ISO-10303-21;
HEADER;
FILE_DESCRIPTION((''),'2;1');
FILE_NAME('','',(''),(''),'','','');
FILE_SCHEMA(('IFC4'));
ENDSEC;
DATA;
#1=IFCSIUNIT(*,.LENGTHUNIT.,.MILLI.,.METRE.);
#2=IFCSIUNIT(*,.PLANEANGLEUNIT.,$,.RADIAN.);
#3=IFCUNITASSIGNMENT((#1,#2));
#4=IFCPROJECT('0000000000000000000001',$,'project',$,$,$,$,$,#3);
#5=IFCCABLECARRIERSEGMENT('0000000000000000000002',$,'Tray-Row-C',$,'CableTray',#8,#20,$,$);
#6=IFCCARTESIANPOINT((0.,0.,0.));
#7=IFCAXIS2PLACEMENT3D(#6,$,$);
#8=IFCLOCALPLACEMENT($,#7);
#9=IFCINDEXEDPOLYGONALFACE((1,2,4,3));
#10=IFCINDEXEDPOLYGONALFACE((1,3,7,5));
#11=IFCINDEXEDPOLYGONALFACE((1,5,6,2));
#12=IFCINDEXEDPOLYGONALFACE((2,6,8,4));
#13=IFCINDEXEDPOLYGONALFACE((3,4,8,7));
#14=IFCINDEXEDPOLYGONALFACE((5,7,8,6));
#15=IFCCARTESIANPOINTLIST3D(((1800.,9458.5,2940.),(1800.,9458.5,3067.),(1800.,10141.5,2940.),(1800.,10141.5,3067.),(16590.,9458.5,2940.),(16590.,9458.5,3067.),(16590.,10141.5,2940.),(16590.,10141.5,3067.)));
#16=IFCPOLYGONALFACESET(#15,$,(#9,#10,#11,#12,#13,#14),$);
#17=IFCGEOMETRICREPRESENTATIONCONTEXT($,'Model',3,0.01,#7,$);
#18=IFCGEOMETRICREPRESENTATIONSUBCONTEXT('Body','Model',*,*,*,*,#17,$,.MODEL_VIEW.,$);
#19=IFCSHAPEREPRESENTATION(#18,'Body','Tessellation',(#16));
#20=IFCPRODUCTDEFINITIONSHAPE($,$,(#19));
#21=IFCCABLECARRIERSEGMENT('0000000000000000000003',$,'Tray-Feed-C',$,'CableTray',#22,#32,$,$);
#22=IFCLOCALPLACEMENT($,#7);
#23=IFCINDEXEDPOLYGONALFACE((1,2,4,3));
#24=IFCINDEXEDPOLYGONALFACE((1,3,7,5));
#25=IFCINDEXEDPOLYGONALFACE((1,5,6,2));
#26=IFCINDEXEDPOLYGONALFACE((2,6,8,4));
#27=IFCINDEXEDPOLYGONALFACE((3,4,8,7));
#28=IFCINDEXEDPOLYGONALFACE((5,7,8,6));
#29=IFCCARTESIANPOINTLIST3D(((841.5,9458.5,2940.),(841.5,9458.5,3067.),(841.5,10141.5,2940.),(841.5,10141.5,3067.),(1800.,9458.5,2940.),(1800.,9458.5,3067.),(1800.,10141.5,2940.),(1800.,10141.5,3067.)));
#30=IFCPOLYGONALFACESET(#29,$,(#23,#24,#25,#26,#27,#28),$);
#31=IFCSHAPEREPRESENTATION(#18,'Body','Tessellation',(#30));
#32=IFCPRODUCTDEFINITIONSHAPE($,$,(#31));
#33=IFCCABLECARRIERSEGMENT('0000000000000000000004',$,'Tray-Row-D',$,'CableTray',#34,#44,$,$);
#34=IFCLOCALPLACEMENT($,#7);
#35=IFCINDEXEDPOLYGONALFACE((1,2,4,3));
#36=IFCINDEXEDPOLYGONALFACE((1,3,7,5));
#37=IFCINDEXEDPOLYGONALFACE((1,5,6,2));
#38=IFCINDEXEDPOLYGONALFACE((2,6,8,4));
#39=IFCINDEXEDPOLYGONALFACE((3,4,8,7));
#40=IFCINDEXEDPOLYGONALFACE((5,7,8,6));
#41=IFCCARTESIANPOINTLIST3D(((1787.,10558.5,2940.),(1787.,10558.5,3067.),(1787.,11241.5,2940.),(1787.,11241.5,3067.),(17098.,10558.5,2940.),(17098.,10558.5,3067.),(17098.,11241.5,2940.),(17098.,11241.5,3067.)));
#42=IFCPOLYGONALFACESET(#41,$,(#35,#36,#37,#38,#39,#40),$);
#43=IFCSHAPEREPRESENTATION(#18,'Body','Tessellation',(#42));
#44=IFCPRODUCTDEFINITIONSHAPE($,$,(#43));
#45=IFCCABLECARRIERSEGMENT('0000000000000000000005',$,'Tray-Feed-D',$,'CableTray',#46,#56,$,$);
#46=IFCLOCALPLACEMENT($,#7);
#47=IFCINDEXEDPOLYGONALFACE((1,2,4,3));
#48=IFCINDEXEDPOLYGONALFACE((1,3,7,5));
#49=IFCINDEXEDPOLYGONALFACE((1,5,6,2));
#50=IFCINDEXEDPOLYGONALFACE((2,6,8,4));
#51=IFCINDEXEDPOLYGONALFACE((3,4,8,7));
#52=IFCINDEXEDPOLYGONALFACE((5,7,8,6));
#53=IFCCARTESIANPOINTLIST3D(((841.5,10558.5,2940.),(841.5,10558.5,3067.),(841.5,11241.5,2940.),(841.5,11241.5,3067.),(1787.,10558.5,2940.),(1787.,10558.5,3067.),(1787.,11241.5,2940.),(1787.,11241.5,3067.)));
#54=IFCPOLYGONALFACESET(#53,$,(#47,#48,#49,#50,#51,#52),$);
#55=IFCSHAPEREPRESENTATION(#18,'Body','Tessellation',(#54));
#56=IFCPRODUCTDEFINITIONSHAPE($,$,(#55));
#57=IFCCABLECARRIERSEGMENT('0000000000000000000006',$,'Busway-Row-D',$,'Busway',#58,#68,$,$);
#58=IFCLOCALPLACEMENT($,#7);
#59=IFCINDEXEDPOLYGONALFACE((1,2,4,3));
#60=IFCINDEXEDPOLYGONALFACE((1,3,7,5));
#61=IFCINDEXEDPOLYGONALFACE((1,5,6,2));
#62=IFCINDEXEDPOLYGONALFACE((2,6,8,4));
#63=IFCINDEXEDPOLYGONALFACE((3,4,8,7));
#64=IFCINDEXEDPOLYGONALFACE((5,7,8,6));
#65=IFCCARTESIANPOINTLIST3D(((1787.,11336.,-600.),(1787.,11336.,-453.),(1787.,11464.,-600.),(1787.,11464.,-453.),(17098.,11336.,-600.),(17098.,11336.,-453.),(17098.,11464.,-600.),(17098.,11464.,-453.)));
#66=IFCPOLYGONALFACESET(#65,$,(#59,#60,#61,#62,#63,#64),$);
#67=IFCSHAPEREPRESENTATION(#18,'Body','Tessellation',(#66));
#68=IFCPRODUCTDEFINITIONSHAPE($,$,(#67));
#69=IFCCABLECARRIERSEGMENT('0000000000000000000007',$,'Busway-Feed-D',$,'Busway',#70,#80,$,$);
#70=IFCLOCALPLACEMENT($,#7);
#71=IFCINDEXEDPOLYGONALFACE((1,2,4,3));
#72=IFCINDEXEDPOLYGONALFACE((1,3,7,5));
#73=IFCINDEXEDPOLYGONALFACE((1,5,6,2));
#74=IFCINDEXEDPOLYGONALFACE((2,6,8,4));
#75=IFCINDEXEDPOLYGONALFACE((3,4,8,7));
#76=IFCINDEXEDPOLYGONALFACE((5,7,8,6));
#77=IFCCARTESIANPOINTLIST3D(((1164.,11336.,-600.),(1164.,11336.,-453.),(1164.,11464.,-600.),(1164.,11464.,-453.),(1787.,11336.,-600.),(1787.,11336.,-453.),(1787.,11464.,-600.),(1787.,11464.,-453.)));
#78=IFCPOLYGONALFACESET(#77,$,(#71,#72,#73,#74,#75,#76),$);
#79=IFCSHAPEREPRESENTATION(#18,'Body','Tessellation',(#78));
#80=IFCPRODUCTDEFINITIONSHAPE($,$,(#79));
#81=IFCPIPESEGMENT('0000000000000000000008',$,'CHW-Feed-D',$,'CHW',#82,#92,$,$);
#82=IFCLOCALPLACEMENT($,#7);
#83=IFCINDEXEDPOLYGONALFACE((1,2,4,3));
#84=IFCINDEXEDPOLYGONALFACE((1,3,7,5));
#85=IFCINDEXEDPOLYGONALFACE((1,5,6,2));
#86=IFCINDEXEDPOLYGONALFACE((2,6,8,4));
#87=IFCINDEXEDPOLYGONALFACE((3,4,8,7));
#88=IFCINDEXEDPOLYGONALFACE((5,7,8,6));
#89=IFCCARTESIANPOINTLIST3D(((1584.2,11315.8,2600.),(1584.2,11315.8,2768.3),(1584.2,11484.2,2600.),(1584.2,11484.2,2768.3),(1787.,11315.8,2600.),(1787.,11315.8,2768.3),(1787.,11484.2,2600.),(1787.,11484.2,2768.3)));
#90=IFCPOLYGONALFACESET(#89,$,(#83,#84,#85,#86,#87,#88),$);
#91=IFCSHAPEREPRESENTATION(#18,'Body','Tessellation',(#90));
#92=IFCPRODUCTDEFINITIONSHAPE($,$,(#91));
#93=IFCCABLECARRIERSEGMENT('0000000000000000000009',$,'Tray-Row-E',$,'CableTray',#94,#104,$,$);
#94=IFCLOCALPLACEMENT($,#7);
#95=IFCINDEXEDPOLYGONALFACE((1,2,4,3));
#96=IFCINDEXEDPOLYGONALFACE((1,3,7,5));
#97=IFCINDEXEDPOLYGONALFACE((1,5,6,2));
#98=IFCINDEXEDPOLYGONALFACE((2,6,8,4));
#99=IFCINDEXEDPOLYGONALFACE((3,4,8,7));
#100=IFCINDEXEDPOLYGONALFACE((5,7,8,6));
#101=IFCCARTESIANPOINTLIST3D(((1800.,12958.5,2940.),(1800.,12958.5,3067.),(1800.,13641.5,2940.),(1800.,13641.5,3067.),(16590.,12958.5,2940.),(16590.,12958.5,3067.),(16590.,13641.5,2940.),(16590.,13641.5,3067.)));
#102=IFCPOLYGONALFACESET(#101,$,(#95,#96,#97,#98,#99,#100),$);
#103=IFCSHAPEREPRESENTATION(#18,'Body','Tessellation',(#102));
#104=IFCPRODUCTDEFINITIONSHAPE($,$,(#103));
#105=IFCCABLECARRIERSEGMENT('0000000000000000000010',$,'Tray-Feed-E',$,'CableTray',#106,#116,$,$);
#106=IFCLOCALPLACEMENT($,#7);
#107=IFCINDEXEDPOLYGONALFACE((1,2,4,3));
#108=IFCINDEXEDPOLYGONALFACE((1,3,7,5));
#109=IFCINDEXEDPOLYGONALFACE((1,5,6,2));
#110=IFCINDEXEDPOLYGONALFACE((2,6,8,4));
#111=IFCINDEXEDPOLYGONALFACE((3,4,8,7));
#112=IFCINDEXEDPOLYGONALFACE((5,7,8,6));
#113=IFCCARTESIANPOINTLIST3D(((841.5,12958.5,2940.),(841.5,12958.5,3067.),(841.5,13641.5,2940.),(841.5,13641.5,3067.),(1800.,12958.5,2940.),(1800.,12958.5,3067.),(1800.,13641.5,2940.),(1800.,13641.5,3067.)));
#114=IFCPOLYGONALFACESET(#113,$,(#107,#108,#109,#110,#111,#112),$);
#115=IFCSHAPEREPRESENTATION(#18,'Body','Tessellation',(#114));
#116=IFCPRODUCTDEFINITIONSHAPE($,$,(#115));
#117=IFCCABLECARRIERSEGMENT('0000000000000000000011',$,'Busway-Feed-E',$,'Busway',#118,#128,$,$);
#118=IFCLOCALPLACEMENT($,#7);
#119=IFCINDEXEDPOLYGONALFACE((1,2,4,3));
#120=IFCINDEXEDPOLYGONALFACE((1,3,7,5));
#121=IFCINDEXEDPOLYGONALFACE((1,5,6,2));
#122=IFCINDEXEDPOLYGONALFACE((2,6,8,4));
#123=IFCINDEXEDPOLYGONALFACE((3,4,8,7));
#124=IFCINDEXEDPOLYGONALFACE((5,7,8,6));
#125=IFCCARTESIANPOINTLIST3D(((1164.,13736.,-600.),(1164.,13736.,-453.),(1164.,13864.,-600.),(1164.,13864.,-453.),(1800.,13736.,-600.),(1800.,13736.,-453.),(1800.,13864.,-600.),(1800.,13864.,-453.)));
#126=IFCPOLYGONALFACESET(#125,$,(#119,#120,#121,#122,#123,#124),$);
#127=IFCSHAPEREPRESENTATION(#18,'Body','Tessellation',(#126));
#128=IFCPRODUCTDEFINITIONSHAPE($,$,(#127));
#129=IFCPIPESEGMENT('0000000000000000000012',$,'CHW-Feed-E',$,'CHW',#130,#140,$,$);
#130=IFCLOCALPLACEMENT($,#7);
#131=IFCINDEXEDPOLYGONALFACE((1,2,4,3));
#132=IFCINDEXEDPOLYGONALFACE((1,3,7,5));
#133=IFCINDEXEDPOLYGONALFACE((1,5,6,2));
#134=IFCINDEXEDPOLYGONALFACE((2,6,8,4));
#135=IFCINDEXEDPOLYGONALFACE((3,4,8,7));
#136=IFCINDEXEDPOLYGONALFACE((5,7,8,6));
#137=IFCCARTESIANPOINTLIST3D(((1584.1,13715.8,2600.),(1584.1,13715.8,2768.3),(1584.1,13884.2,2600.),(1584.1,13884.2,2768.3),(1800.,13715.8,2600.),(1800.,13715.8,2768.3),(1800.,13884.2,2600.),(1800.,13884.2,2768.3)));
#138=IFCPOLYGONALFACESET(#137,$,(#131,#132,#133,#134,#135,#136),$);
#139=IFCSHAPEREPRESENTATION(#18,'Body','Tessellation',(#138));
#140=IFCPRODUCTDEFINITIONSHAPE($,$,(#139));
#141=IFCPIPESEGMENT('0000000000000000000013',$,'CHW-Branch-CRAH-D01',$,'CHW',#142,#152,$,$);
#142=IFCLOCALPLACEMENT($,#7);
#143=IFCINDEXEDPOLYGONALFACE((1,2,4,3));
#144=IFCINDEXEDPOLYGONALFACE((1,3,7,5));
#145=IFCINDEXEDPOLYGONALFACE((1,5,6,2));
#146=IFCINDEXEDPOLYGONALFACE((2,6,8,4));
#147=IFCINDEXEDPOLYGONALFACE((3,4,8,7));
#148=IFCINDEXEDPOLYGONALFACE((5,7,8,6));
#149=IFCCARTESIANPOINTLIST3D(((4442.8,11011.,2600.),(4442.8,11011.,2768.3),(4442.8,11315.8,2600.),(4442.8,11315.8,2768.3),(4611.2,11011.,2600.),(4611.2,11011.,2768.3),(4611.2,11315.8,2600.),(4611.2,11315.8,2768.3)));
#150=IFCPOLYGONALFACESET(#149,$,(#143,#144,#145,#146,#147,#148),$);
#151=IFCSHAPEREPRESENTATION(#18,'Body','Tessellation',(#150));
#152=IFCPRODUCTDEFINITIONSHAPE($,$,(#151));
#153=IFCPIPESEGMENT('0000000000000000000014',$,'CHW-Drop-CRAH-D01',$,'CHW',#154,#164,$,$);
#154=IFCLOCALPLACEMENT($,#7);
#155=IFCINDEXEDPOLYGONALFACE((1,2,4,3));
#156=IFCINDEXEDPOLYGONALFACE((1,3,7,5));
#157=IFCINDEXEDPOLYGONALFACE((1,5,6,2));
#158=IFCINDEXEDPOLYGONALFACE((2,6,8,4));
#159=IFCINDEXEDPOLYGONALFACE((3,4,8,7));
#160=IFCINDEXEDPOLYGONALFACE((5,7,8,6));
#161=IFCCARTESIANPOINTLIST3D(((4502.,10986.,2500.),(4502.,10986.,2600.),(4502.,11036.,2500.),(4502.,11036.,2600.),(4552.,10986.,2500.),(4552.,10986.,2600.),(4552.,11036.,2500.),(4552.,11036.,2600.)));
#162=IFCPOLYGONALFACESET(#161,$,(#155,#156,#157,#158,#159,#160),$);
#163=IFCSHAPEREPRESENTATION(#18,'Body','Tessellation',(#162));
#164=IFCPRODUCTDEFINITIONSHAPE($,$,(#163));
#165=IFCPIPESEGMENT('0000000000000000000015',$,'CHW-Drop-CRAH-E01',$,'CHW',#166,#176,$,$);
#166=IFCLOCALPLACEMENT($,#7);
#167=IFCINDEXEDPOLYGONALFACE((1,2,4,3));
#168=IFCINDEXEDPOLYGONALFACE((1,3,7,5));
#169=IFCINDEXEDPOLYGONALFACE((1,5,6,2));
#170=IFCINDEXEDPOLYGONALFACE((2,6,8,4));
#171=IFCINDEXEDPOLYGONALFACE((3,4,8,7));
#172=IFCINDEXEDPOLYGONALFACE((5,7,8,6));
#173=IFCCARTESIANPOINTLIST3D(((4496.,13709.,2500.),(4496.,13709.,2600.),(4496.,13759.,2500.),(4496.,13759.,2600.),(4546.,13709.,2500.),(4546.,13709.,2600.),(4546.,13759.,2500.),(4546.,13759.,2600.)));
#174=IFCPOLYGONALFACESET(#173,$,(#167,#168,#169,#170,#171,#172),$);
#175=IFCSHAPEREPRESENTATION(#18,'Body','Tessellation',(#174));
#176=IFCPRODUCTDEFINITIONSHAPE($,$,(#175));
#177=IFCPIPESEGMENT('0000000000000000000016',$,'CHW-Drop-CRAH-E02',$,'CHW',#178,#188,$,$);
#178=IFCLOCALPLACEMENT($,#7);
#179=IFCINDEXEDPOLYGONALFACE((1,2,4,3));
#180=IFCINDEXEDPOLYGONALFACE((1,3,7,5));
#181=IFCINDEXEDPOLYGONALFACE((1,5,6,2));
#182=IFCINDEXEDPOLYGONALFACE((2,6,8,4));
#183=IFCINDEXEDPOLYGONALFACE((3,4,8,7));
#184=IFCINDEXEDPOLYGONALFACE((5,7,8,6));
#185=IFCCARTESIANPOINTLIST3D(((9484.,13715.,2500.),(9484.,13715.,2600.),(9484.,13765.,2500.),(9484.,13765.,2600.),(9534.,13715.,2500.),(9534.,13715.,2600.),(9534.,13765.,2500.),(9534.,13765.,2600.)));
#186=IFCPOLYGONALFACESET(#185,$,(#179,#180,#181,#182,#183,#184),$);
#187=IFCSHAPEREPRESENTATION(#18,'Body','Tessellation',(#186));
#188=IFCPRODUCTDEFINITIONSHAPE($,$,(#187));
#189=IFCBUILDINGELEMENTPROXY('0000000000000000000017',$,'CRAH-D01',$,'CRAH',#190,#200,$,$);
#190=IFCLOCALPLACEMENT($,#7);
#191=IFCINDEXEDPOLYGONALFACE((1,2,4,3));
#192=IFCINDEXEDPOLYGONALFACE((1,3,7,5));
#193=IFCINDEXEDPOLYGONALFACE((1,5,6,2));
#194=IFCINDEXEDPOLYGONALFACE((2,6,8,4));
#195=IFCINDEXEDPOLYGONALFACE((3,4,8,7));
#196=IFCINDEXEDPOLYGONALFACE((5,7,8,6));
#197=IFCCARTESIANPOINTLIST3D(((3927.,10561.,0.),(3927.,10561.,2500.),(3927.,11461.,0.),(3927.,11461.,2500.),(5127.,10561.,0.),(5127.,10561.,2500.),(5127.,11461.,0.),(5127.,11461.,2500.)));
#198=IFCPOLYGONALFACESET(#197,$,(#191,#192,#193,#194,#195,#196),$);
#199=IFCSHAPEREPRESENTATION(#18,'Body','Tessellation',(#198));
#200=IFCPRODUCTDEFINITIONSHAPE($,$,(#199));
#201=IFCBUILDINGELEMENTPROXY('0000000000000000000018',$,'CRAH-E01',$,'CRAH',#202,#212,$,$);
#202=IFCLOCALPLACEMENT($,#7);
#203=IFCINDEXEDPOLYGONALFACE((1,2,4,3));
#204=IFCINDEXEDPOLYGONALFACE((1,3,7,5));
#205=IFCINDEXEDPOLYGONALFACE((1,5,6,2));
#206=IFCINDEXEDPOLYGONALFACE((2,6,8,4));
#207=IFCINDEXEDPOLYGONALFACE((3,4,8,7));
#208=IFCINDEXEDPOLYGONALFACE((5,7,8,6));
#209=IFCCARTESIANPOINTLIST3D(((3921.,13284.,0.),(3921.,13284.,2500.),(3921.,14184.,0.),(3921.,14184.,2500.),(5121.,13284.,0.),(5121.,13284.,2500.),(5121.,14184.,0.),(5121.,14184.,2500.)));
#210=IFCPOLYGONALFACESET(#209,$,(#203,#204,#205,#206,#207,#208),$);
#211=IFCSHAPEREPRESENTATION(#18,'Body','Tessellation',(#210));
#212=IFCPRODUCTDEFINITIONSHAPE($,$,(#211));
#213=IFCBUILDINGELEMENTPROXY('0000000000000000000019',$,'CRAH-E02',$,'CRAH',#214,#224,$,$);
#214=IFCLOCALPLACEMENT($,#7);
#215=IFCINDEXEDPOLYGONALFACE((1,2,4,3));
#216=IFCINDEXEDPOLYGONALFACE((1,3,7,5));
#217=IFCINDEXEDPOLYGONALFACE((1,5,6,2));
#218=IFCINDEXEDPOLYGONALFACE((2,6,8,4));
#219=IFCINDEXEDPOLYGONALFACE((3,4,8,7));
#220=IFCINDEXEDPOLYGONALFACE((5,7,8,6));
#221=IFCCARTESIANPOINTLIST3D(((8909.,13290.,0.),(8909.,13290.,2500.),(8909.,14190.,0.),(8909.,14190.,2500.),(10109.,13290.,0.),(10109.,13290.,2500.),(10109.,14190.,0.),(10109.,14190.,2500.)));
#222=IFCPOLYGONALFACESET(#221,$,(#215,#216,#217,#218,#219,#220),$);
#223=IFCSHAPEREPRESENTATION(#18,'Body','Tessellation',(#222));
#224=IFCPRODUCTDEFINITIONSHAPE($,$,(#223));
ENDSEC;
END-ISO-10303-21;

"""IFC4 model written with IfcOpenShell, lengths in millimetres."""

from ifc_helpers import new_model, si_unit, frame, origin, place, context, subcontext, project, rectangle, extrude, element, save


model = new_model("IFC4")

# Units and contexts
model_context = context("Model", 3, precision=0.01, world=origin())
body_context = subcontext(model_context, "Body", "Model", "MODEL_VIEW")
ifc_project = project(units=[si_unit("LENGTHUNIT", "METRE", prefix="MILLI"), si_unit("PLANEANGLEUNIT", "RADIAN")])

# Cable carrier segments
placement = place(None, origin())
cable_carrier_segment_1_placement = place(placement, frame((9195.0, 9800.0, 2940.0)))
element("IfcCableCarrierSegment", 1, at=cable_carrier_segment_1_placement, Name="Tray-Row-C", ObjectType="CableTray", context=body_context, shape_type="SweptSolid", body=[
    extrude(rectangle(XDim=14790.0, YDim=683.0), origin(), (0.0, 0.0, 1.0), 127.0),
])
cable_carrier_segment_2_placement = place(placement, frame((1320.8, 9800.0, 2940.0)))
element("IfcCableCarrierSegment", 2, at=cable_carrier_segment_2_placement, Name="Tray-Feed-C", ObjectType="CableTray", context=body_context, shape_type="SweptSolid", body=[
    extrude(rectangle(XDim=958.5, YDim=683.0), origin(), (0.0, 0.0, 1.0), 127.0),
])
cable_carrier_segment_3_placement = place(placement, frame((9442.5, 10900.0, 2940.0)))
element("IfcCableCarrierSegment", 3, at=cable_carrier_segment_3_placement, Name="Tray-Row-D", ObjectType="CableTray", context=body_context, shape_type="SweptSolid", body=[
    extrude(rectangle(XDim=15311.0, YDim=683.0), origin(), (0.0, 0.0, 1.0), 127.0),
])
cable_carrier_segment_4_placement = place(placement, frame((1314.2, 10900.0, 2940.0)))
element("IfcCableCarrierSegment", 4, at=cable_carrier_segment_4_placement, Name="Tray-Feed-D", ObjectType="CableTray", context=body_context, shape_type="SweptSolid", body=[
    extrude(rectangle(XDim=945.5, YDim=683.0), origin(), (0.0, 0.0, 1.0), 127.0),
])
cable_carrier_segment_5_placement = place(placement, frame((9442.5, 11400.0, -600.0)))
element("IfcCableCarrierSegment", 5, at=cable_carrier_segment_5_placement, Name="Busway-Row-D", ObjectType="Busway", context=body_context, shape_type="SweptSolid", body=[
    extrude(rectangle(XDim=15311.0, YDim=128.0), origin(), (0.0, 0.0, 1.0), 147.0),
])
cable_carrier_segment_6_placement = place(placement, frame((1475.5, 11400.0, -600.0)))
element("IfcCableCarrierSegment", 6, at=cable_carrier_segment_6_placement, Name="Busway-Feed-D", ObjectType="Busway", context=body_context, shape_type="SweptSolid", body=[
    extrude(rectangle(XDim=623.0, YDim=128.0), origin(), (0.0, 0.0, 1.0), 147.0),
])

# Pipe segment
pipe_segment_1_placement = place(placement, frame((1685.6, 11400.0, 2600.0)))
element("IfcPipeSegment", 7, at=pipe_segment_1_placement, Name="CHW-Feed-D", ObjectType="CHW", context=body_context, shape_type="SweptSolid", body=[
    extrude(rectangle(XDim=202.8, YDim=168.3), origin(), (0.0, 0.0, 1.0), 168.3),
])

# Cable carrier segments
cable_carrier_segment_7_placement = place(placement, frame((9195.0, 13300.0, 2940.0)))
element("IfcCableCarrierSegment", 8, at=cable_carrier_segment_7_placement, Name="Tray-Row-E", ObjectType="CableTray", context=body_context, shape_type="SweptSolid", body=[
    extrude(rectangle(XDim=14790.0, YDim=683.0), origin(), (0.0, 0.0, 1.0), 127.0),
])
cable_carrier_segment_8_placement = place(placement, frame((1320.8, 13300.0, 2940.0)))
element("IfcCableCarrierSegment", 9, at=cable_carrier_segment_8_placement, Name="Tray-Feed-E", ObjectType="CableTray", context=body_context, shape_type="SweptSolid", body=[
    extrude(rectangle(XDim=958.5, YDim=683.0), origin(), (0.0, 0.0, 1.0), 127.0),
])
cable_carrier_segment_9_placement = place(placement, frame((1482.0, 13800.0, -600.0)))
element("IfcCableCarrierSegment", 10, at=cable_carrier_segment_9_placement, Name="Busway-Feed-E", ObjectType="Busway", context=body_context, shape_type="SweptSolid", body=[
    extrude(rectangle(XDim=636.0, YDim=128.0), origin(), (0.0, 0.0, 1.0), 147.0),
])

# Pipe segments
pipe_segment_2_placement = place(placement, frame((1692.1, 13800.0, 2600.0)))
element("IfcPipeSegment", 11, at=pipe_segment_2_placement, Name="CHW-Feed-E", ObjectType="CHW", context=body_context, shape_type="SweptSolid", body=[
    extrude(rectangle(XDim=215.8, YDim=168.3), origin(), (0.0, 0.0, 1.0), 168.3),
])
pipe_segment_3_placement = place(placement, frame((4527.0, 11163.4, 2600.0)))
element("IfcPipeSegment", 12, at=pipe_segment_3_placement, Name="CHW-Branch-CRAH-D01", ObjectType="CHW", context=body_context, shape_type="SweptSolid", body=[
    extrude(rectangle(XDim=168.3, YDim=304.9), origin(), (0.0, 0.0, 1.0), 168.3),
])
for number, where, name in (
    (13, (4527.0, 11011.0, 2500.0), "CHW-Drop-CRAH-D01"),
    (14, (4521.0, 13734.0, 2500.0), "CHW-Drop-CRAH-E01"),
    (15, (9509.0, 13740.0, 2500.0), "CHW-Drop-CRAH-E02"),
):
    element("IfcPipeSegment", number, at=place(placement, frame(where)), Name=name, ObjectType="CHW", context=body_context, shape_type="SweptSolid", body=[
        extrude(rectangle(XDim=50.0, YDim=50.0), origin(), (0.0, 0.0, 1.0), 100.0),
    ])

# Building element proxies
for number, where, name in (
    (16, (4527.0, 11011.0, 0.0), "CRAH-D01"),
    (17, (4521.0, 13734.0, 0.0), "CRAH-E01"),
    (18, (9509.0, 13740.0, 0.0), "CRAH-E02"),
):
    element("IfcBuildingElementProxy", number, at=place(placement, frame(where)), Name=name, ObjectType="CRAH", context=body_context, shape_type="SweptSolid", body=[
        extrude(rectangle(XDim=1200.0, YDim=900.0), origin(), (0.0, 0.0, 1.0), 2500.0),
    ])

save(model, "model.ifc")
